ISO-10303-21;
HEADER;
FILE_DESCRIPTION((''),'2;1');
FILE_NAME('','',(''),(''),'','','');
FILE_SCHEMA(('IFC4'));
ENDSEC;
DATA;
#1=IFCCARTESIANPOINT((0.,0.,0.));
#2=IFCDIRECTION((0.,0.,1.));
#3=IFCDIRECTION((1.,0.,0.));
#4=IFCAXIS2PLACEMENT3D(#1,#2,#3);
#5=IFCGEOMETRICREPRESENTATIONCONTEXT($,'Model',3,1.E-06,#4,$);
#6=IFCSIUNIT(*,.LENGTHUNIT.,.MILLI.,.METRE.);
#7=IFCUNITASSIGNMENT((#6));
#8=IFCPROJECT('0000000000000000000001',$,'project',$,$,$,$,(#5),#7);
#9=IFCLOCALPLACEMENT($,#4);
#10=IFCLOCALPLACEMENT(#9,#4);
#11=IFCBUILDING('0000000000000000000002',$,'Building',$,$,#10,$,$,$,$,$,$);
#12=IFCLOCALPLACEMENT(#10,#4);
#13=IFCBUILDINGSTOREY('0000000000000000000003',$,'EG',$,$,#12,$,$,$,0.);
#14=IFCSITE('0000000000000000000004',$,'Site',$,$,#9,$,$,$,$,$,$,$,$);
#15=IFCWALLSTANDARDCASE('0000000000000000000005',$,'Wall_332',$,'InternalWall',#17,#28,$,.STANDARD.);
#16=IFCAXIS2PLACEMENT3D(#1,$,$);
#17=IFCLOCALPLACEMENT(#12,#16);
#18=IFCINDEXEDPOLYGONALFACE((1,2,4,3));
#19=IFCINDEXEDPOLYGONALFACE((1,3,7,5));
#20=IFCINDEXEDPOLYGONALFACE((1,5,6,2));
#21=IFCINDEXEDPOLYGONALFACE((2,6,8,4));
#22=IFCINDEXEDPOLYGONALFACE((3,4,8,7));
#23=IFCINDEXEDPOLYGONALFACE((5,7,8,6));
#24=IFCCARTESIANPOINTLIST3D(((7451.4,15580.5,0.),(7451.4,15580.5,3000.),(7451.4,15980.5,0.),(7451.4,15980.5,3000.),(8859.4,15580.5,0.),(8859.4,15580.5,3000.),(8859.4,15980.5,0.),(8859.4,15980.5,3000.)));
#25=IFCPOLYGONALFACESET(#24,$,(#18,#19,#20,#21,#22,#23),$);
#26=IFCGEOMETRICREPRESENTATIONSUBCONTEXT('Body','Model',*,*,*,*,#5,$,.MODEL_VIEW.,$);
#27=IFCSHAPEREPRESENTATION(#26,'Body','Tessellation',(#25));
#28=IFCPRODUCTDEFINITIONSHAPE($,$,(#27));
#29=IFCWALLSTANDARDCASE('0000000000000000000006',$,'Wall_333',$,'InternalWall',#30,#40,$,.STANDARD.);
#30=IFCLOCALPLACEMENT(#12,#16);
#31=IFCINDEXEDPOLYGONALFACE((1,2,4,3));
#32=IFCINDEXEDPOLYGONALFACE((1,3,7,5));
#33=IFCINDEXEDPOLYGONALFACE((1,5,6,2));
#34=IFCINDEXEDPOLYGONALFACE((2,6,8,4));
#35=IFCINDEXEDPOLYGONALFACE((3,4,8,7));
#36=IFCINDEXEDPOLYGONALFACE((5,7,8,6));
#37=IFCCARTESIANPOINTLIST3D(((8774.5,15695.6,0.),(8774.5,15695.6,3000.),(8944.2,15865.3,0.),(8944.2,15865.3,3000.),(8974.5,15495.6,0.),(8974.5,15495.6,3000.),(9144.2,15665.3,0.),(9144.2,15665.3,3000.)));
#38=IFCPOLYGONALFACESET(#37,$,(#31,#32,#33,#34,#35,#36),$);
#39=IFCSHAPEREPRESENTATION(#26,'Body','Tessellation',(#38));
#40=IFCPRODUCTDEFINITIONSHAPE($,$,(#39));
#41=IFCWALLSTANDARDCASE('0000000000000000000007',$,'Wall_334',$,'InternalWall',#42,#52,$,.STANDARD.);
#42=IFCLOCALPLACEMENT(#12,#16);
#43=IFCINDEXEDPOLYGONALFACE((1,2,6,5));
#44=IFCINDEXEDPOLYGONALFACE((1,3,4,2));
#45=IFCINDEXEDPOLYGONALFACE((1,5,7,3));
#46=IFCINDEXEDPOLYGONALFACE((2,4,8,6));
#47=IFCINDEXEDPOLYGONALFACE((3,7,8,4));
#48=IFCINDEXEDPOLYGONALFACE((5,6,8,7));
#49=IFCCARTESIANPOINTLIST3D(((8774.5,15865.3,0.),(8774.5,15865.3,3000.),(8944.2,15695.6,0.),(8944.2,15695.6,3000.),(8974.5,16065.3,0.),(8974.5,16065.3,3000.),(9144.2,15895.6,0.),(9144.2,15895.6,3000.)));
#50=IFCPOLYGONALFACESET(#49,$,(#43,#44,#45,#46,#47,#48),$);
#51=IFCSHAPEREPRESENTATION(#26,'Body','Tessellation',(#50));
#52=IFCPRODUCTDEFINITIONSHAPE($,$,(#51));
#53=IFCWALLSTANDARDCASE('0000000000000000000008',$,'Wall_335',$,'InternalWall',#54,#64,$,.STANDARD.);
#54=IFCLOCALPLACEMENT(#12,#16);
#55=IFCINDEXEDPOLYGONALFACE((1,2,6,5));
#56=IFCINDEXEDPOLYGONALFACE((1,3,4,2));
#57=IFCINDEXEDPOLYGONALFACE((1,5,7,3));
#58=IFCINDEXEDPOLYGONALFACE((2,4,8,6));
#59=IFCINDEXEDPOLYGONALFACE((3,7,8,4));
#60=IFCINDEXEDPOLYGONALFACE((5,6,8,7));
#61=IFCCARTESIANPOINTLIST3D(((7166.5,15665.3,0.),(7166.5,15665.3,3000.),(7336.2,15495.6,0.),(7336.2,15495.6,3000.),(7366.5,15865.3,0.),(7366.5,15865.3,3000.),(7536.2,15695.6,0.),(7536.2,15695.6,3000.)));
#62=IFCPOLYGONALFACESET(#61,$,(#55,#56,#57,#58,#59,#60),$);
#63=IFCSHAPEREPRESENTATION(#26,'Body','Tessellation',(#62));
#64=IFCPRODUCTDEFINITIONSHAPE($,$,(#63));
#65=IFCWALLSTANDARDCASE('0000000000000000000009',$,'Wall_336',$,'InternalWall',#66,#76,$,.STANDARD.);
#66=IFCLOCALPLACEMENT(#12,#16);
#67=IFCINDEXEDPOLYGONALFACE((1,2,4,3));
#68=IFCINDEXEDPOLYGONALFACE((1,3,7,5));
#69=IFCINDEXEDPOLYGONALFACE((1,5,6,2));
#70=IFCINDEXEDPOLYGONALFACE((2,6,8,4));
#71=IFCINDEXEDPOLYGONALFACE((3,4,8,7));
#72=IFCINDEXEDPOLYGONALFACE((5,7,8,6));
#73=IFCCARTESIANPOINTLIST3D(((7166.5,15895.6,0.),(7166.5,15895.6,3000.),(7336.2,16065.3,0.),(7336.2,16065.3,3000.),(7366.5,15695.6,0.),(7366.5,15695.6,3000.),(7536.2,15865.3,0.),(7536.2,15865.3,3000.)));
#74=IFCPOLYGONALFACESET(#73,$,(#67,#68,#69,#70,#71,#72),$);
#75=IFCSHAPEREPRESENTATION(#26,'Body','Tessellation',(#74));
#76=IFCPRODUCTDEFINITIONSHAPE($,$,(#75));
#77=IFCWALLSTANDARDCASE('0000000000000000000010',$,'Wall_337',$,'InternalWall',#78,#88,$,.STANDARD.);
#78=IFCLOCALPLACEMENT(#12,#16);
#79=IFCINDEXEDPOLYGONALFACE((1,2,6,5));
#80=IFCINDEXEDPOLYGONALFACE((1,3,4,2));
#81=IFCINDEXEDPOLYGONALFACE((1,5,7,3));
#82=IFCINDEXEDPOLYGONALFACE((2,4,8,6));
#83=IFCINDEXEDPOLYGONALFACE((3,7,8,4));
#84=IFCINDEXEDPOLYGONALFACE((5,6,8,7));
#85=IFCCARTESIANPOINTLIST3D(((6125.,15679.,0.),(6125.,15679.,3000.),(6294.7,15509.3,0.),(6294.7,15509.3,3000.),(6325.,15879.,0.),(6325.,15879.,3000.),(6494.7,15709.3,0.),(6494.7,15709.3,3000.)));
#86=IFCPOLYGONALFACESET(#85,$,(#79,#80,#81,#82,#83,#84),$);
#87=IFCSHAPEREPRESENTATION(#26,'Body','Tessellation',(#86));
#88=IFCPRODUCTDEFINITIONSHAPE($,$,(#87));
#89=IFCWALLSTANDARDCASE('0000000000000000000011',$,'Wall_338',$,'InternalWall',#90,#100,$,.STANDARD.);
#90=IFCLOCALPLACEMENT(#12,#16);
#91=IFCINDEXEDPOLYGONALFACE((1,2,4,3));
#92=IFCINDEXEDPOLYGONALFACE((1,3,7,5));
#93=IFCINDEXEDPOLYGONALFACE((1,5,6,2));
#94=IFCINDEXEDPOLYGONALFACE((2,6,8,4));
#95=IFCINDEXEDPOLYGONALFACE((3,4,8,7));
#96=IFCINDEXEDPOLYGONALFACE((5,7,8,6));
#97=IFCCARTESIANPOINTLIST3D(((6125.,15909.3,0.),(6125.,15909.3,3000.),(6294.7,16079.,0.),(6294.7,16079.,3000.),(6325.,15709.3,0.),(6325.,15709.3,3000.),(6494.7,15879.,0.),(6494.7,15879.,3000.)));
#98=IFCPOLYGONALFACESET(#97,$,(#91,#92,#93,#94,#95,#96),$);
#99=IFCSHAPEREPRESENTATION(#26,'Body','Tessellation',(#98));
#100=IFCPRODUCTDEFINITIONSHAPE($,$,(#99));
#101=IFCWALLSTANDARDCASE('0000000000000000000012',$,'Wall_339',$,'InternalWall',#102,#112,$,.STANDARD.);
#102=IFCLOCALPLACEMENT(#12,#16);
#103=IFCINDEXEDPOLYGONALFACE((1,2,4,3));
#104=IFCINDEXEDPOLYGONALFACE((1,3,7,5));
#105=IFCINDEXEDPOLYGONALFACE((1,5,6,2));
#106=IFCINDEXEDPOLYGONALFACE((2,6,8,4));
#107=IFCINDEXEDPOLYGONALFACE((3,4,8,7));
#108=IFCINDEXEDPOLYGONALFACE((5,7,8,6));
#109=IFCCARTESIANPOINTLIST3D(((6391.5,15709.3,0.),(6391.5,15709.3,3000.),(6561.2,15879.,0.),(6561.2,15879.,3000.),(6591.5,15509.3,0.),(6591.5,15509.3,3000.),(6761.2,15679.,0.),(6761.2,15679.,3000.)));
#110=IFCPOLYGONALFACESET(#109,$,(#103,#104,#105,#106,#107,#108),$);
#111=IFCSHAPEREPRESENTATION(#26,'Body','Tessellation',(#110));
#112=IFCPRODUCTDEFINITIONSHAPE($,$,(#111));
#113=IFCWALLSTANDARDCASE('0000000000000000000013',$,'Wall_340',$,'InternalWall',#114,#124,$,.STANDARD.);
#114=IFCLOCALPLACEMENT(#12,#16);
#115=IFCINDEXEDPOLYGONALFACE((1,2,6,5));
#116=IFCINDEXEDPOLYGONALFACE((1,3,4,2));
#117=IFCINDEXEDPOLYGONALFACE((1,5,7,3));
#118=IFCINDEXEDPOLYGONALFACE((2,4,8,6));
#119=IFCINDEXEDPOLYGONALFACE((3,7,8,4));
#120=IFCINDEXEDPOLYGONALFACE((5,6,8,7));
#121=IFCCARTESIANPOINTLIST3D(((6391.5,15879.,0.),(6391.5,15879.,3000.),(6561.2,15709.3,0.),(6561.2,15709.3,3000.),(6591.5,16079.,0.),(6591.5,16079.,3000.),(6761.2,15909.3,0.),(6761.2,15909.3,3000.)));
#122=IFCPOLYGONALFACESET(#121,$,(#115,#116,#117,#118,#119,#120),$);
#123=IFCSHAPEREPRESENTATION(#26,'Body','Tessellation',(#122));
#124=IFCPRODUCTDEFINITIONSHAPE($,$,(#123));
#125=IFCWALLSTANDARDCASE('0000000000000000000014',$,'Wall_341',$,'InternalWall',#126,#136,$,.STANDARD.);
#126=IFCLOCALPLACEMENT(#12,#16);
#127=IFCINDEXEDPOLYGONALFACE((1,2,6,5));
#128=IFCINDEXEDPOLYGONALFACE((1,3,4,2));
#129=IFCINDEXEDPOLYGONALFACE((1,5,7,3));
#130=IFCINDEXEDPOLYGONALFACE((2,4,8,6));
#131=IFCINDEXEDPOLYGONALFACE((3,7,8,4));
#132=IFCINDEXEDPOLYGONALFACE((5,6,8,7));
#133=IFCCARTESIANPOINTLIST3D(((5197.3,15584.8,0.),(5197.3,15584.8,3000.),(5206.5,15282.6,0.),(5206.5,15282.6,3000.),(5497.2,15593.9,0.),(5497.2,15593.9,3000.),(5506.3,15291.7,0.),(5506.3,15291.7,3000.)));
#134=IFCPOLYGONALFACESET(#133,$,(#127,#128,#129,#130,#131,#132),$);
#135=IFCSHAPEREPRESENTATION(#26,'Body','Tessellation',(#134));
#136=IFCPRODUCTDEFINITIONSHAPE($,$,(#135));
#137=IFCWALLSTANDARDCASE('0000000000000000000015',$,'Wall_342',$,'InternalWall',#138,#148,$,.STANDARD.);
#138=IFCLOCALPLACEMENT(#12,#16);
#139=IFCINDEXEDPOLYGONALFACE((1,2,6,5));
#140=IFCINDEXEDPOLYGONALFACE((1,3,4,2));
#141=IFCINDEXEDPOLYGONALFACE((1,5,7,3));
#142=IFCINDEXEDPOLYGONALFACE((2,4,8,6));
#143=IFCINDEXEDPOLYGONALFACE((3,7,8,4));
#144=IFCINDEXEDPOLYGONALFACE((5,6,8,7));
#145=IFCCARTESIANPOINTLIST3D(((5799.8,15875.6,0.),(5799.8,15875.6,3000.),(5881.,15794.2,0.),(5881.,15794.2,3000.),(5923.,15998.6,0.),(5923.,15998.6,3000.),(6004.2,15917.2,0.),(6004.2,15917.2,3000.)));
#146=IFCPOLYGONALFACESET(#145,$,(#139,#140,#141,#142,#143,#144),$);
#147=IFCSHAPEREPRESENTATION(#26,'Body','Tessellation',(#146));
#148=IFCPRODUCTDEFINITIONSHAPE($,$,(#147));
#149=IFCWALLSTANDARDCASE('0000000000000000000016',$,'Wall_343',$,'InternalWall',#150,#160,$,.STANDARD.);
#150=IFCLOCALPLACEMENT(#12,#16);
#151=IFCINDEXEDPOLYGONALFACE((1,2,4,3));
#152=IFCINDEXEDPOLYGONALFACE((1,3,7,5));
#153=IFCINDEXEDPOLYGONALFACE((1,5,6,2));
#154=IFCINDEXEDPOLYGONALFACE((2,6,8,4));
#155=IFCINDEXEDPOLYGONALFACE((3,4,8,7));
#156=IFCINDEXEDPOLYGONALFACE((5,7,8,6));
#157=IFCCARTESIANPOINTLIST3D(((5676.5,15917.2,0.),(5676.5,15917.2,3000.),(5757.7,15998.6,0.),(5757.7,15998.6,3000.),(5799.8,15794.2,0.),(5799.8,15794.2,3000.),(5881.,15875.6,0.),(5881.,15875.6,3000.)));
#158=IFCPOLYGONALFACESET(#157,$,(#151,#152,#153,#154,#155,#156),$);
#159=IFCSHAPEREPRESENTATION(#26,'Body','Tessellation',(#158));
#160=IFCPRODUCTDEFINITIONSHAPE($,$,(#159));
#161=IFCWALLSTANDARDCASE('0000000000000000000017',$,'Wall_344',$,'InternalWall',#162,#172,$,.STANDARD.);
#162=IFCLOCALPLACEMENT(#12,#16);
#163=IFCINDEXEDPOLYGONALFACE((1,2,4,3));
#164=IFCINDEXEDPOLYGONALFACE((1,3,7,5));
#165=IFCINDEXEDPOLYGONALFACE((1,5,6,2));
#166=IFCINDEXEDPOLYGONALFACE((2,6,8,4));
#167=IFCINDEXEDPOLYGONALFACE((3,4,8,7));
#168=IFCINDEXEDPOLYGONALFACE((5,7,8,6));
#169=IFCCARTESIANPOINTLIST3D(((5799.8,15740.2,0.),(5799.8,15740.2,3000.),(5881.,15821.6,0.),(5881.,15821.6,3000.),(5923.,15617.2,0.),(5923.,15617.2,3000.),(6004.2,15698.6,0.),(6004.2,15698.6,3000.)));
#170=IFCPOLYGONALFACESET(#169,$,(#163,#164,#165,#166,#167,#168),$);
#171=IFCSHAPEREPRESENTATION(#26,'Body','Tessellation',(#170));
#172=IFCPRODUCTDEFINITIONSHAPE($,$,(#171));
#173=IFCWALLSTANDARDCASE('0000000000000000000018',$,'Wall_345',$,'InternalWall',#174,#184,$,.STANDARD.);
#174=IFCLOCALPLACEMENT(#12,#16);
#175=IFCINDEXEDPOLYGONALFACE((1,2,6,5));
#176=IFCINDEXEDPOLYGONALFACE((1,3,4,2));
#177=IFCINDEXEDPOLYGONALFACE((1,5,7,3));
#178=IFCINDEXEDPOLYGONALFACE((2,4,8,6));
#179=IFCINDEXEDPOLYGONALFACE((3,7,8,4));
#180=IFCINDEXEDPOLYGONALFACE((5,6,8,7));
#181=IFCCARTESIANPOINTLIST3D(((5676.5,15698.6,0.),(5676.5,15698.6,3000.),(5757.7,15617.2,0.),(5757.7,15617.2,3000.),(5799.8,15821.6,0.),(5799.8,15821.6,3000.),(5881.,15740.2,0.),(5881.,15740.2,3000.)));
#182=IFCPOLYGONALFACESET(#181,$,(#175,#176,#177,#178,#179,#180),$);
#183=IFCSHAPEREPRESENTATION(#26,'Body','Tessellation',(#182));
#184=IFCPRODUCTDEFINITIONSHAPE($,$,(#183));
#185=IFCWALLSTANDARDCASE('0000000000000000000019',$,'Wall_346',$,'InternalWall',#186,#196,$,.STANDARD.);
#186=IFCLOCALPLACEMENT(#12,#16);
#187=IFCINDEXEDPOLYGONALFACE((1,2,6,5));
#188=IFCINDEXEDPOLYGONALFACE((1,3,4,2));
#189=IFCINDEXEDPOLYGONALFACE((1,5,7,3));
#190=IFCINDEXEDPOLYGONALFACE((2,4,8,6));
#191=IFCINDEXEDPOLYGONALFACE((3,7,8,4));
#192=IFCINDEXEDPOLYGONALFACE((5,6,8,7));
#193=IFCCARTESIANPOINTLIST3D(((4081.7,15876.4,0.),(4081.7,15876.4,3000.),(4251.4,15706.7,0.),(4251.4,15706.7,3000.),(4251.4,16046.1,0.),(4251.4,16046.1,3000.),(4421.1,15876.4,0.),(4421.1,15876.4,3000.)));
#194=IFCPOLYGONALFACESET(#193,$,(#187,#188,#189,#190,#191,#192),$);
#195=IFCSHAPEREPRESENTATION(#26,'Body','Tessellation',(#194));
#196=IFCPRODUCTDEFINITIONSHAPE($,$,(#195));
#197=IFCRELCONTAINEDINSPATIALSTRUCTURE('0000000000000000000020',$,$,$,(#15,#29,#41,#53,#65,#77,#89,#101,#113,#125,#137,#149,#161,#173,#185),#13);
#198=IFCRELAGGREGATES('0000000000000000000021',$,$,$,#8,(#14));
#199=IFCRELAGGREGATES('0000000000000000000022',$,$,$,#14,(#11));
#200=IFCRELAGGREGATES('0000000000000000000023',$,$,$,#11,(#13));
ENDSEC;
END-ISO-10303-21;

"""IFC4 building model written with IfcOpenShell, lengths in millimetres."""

from ifc_helpers import new_model, si_unit, frame, origin_with_axes, place, context, subcontext, project, spatial, rectangle, extrude, element, save


model = new_model("IFC4")

# Units and contexts
model_context = context("Model", 3, precision=1e-06, world=origin_with_axes())
body_context = subcontext(model_context, "Body", "Model", "MODEL_VIEW")
ifc_project = project(units=[si_unit("LENGTHUNIT", "METRE", prefix="MILLI")], contexts=[model_context])

# Site, building, storey
site_placement = place(None, origin_with_axes())
site = spatial("IfcSite", under=ifc_project, at=site_placement, Name="Site")
building_placement = place(site_placement, origin_with_axes())
building = spatial("IfcBuilding", under=site, at=building_placement, Name="Building")
storey_placement = place(building_placement, origin_with_axes())
storey = spatial("IfcBuildingStorey", under=building, at=storey_placement, Name="EG", Elevation=0.0)

# Walls
wall_1_placement = place(storey_placement, origin_with_axes())
element("IfcWallStandardCase", 1, at=wall_1_placement, inside=storey, Name="Wall_332", ObjectType="InternalWall", PredefinedType="STANDARD", context=body_context, shape_type="SweptSolid", body=[
    extrude(rectangle(XDim=1408.0, YDim=400.0), frame((8155.4, 15780.5, 0.0), z_axis=(0.0, 0.0, 1.0), x_axis=(-1.0, 0.0, 0.0)), (0.0, 0.0, 1.0), 3000.0),
])
wall_2_placement = place(storey_placement, origin_with_axes())
element("IfcWallStandardCase", 2, at=wall_2_placement, inside=storey, Name="Wall_333", ObjectType="InternalWall", PredefinedType="STANDARD", context=body_context, shape_type="SweptSolid", body=[
    extrude(rectangle(XDim=282.8, YDim=240.0), frame((8959.4, 15680.5, 0.0), z_axis=(0.0, 0.0, 1.0), x_axis=(0.707107, -0.707107, 0.0)), (0.0, 0.0, 1.0), 3000.0),
])
wall_3_placement = place(storey_placement, origin_with_axes())
element("IfcWallStandardCase", 3, at=wall_3_placement, inside=storey, Name="Wall_334", ObjectType="InternalWall", PredefinedType="STANDARD", context=body_context, shape_type="SweptSolid", body=[
    extrude(rectangle(XDim=282.8, YDim=240.0), frame((8959.4, 15880.5, 0.0), z_axis=(0.0, 0.0, 1.0), x_axis=(0.707107, 0.707107, 0.0)), (0.0, 0.0, 1.0), 3000.0),
])
wall_4_placement = place(storey_placement, origin_with_axes())
element("IfcWallStandardCase", 4, at=wall_4_placement, inside=storey, Name="Wall_335", ObjectType="InternalWall", PredefinedType="STANDARD", context=body_context, shape_type="SweptSolid", body=[
    extrude(rectangle(XDim=282.8, YDim=240.0), frame((7351.4, 15680.5, 0.0), z_axis=(0.0, 0.0, 1.0), x_axis=(-0.707107, -0.707107, 0.0)), (0.0, 0.0, 1.0), 3000.0),
])
wall_5_placement = place(storey_placement, origin_with_axes())
element("IfcWallStandardCase", 5, at=wall_5_placement, inside=storey, Name="Wall_336", ObjectType="InternalWall", PredefinedType="STANDARD", context=body_context, shape_type="SweptSolid", body=[
    extrude(rectangle(XDim=282.8, YDim=240.0), frame((7351.4, 15880.5, 0.0), z_axis=(0.0, 0.0, 1.0), x_axis=(-0.707107, 0.707107, 0.0)), (0.0, 0.0, 1.0), 3000.0),
])
wall_6_placement = place(storey_placement, origin_with_axes())
element("IfcWallStandardCase", 6, at=wall_6_placement, inside=storey, Name="Wall_337", ObjectType="InternalWall", PredefinedType="STANDARD", context=body_context, shape_type="SweptSolid", body=[
    extrude(rectangle(XDim=282.8, YDim=240.0), frame((6309.9, 15694.2, 0.0), z_axis=(0.0, 0.0, 1.0), x_axis=(-0.707107, -0.707107, 0.0)), (0.0, 0.0, 1.0), 3000.0),
])
wall_7_placement = place(storey_placement, origin_with_axes())
element("IfcWallStandardCase", 7, at=wall_7_placement, inside=storey, Name="Wall_338", ObjectType="InternalWall", PredefinedType="STANDARD", context=body_context, shape_type="SweptSolid", body=[
    extrude(rectangle(XDim=282.8, YDim=240.0), frame((6309.9, 15894.2, 0.0), z_axis=(0.0, 0.0, 1.0), x_axis=(-0.707107, 0.707107, 0.0)), (0.0, 0.0, 1.0), 3000.0),
])
wall_8_placement = place(storey_placement, origin_with_axes())
element("IfcWallStandardCase", 8, at=wall_8_placement, inside=storey, Name="Wall_339", ObjectType="InternalWall", PredefinedType="STANDARD", context=body_context, shape_type="SweptSolid", body=[
    extrude(rectangle(XDim=282.8, YDim=240.0), frame((6576.4, 15694.2, 0.0), z_axis=(0.0, 0.0, 1.0), x_axis=(0.707107, -0.707107, 0.0)), (0.0, 0.0, 1.0), 3000.0),
])
wall_9_placement = place(storey_placement, origin_with_axes())
element("IfcWallStandardCase", 9, at=wall_9_placement, inside=storey, Name="Wall_340", ObjectType="InternalWall", PredefinedType="STANDARD", context=body_context, shape_type="SweptSolid", body=[
    extrude(rectangle(XDim=282.8, YDim=240.0), frame((6576.4, 15894.2, 0.0), z_axis=(0.0, 0.0, 1.0), x_axis=(0.707107, 0.707107, 0.0)), (0.0, 0.0, 1.0), 3000.0),
])
wall_10_placement = place(storey_placement, origin_with_axes())
element("IfcWallStandardCase", 10, at=wall_10_placement, inside=storey, Name="Wall_341", ObjectType="InternalWall", PredefinedType="STANDARD", context=body_context, shape_type="SweptSolid", body=[
    extrude(rectangle(XDim=302.3, YDim=300.0), frame((5351.8, 15438.2, 0.0), z_axis=(0.0, 0.0, 1.0), x_axis=(-0.030206, 0.999544, 0.0)), (0.0, 0.0, 1.0), 3000.0),
])
wall_11_placement = place(storey_placement, origin_with_axes())
element("IfcWallStandardCase", 11, at=wall_11_placement, inside=storey, Name="Wall_342", ObjectType="InternalWall", PredefinedType="STANDARD", context=body_context, shape_type="SweptSolid", body=[
    extrude(rectangle(XDim=174.1, YDim=115.0), frame((5902.0, 15896.4, 0.0), z_axis=(0.0, 0.0, 1.0), x_axis=(0.707824, 0.706389, 0.0)), (0.0, 0.0, 1.0), 3000.0),
])
wall_12_placement = place(storey_placement, origin_with_axes())
element("IfcWallStandardCase", 12, at=wall_12_placement, inside=storey, Name="Wall_343", ObjectType="InternalWall", PredefinedType="STANDARD", context=body_context, shape_type="SweptSolid", body=[
    extrude(rectangle(XDim=174.1, YDim=115.0), frame((5778.7, 15896.4, 0.0), z_axis=(0.0, 0.0, 1.0), x_axis=(-0.707824, 0.706389, 0.0)), (0.0, 0.0, 1.0), 3000.0),
])
wall_13_placement = place(storey_placement, origin_with_axes())
element("IfcWallStandardCase", 13, at=wall_13_placement, inside=storey, Name="Wall_344", ObjectType="InternalWall", PredefinedType="STANDARD", context=body_context, shape_type="SweptSolid", body=[
    extrude(rectangle(XDim=174.1, YDim=115.0), frame((5902.0, 15719.4, 0.0), z_axis=(0.0, 0.0, 1.0), x_axis=(0.707824, -0.706389, 0.0)), (0.0, 0.0, 1.0), 3000.0),
])
wall_14_placement = place(storey_placement, origin_with_axes())
element("IfcWallStandardCase", 14, at=wall_14_placement, inside=storey, Name="Wall_345", ObjectType="InternalWall", PredefinedType="STANDARD", context=body_context, shape_type="SweptSolid", body=[
    extrude(rectangle(XDim=174.1, YDim=115.0), frame((5778.7, 15719.4, 0.0), z_axis=(0.0, 0.0, 1.0), x_axis=(-0.707824, -0.706389, 0.0)), (0.0, 0.0, 1.0), 3000.0),
])
wall_15_placement = place(storey_placement, origin_with_axes())
element("IfcWallStandardCase", 15, at=wall_15_placement, inside=storey, Name="Wall_346", ObjectType="InternalWall", PredefinedType="STANDARD", context=body_context, shape_type="SweptSolid", body=[
    extrude(rectangle(XDim=240.0, YDim=240.0), frame((4251.4, 15876.4, 0.0), z_axis=(0.0, 0.0, 1.0), x_axis=(-0.707107, -0.707107, 0.0)), (0.0, 0.0, 1.0), 3000.0),
])

save(model, "model.ifc")
